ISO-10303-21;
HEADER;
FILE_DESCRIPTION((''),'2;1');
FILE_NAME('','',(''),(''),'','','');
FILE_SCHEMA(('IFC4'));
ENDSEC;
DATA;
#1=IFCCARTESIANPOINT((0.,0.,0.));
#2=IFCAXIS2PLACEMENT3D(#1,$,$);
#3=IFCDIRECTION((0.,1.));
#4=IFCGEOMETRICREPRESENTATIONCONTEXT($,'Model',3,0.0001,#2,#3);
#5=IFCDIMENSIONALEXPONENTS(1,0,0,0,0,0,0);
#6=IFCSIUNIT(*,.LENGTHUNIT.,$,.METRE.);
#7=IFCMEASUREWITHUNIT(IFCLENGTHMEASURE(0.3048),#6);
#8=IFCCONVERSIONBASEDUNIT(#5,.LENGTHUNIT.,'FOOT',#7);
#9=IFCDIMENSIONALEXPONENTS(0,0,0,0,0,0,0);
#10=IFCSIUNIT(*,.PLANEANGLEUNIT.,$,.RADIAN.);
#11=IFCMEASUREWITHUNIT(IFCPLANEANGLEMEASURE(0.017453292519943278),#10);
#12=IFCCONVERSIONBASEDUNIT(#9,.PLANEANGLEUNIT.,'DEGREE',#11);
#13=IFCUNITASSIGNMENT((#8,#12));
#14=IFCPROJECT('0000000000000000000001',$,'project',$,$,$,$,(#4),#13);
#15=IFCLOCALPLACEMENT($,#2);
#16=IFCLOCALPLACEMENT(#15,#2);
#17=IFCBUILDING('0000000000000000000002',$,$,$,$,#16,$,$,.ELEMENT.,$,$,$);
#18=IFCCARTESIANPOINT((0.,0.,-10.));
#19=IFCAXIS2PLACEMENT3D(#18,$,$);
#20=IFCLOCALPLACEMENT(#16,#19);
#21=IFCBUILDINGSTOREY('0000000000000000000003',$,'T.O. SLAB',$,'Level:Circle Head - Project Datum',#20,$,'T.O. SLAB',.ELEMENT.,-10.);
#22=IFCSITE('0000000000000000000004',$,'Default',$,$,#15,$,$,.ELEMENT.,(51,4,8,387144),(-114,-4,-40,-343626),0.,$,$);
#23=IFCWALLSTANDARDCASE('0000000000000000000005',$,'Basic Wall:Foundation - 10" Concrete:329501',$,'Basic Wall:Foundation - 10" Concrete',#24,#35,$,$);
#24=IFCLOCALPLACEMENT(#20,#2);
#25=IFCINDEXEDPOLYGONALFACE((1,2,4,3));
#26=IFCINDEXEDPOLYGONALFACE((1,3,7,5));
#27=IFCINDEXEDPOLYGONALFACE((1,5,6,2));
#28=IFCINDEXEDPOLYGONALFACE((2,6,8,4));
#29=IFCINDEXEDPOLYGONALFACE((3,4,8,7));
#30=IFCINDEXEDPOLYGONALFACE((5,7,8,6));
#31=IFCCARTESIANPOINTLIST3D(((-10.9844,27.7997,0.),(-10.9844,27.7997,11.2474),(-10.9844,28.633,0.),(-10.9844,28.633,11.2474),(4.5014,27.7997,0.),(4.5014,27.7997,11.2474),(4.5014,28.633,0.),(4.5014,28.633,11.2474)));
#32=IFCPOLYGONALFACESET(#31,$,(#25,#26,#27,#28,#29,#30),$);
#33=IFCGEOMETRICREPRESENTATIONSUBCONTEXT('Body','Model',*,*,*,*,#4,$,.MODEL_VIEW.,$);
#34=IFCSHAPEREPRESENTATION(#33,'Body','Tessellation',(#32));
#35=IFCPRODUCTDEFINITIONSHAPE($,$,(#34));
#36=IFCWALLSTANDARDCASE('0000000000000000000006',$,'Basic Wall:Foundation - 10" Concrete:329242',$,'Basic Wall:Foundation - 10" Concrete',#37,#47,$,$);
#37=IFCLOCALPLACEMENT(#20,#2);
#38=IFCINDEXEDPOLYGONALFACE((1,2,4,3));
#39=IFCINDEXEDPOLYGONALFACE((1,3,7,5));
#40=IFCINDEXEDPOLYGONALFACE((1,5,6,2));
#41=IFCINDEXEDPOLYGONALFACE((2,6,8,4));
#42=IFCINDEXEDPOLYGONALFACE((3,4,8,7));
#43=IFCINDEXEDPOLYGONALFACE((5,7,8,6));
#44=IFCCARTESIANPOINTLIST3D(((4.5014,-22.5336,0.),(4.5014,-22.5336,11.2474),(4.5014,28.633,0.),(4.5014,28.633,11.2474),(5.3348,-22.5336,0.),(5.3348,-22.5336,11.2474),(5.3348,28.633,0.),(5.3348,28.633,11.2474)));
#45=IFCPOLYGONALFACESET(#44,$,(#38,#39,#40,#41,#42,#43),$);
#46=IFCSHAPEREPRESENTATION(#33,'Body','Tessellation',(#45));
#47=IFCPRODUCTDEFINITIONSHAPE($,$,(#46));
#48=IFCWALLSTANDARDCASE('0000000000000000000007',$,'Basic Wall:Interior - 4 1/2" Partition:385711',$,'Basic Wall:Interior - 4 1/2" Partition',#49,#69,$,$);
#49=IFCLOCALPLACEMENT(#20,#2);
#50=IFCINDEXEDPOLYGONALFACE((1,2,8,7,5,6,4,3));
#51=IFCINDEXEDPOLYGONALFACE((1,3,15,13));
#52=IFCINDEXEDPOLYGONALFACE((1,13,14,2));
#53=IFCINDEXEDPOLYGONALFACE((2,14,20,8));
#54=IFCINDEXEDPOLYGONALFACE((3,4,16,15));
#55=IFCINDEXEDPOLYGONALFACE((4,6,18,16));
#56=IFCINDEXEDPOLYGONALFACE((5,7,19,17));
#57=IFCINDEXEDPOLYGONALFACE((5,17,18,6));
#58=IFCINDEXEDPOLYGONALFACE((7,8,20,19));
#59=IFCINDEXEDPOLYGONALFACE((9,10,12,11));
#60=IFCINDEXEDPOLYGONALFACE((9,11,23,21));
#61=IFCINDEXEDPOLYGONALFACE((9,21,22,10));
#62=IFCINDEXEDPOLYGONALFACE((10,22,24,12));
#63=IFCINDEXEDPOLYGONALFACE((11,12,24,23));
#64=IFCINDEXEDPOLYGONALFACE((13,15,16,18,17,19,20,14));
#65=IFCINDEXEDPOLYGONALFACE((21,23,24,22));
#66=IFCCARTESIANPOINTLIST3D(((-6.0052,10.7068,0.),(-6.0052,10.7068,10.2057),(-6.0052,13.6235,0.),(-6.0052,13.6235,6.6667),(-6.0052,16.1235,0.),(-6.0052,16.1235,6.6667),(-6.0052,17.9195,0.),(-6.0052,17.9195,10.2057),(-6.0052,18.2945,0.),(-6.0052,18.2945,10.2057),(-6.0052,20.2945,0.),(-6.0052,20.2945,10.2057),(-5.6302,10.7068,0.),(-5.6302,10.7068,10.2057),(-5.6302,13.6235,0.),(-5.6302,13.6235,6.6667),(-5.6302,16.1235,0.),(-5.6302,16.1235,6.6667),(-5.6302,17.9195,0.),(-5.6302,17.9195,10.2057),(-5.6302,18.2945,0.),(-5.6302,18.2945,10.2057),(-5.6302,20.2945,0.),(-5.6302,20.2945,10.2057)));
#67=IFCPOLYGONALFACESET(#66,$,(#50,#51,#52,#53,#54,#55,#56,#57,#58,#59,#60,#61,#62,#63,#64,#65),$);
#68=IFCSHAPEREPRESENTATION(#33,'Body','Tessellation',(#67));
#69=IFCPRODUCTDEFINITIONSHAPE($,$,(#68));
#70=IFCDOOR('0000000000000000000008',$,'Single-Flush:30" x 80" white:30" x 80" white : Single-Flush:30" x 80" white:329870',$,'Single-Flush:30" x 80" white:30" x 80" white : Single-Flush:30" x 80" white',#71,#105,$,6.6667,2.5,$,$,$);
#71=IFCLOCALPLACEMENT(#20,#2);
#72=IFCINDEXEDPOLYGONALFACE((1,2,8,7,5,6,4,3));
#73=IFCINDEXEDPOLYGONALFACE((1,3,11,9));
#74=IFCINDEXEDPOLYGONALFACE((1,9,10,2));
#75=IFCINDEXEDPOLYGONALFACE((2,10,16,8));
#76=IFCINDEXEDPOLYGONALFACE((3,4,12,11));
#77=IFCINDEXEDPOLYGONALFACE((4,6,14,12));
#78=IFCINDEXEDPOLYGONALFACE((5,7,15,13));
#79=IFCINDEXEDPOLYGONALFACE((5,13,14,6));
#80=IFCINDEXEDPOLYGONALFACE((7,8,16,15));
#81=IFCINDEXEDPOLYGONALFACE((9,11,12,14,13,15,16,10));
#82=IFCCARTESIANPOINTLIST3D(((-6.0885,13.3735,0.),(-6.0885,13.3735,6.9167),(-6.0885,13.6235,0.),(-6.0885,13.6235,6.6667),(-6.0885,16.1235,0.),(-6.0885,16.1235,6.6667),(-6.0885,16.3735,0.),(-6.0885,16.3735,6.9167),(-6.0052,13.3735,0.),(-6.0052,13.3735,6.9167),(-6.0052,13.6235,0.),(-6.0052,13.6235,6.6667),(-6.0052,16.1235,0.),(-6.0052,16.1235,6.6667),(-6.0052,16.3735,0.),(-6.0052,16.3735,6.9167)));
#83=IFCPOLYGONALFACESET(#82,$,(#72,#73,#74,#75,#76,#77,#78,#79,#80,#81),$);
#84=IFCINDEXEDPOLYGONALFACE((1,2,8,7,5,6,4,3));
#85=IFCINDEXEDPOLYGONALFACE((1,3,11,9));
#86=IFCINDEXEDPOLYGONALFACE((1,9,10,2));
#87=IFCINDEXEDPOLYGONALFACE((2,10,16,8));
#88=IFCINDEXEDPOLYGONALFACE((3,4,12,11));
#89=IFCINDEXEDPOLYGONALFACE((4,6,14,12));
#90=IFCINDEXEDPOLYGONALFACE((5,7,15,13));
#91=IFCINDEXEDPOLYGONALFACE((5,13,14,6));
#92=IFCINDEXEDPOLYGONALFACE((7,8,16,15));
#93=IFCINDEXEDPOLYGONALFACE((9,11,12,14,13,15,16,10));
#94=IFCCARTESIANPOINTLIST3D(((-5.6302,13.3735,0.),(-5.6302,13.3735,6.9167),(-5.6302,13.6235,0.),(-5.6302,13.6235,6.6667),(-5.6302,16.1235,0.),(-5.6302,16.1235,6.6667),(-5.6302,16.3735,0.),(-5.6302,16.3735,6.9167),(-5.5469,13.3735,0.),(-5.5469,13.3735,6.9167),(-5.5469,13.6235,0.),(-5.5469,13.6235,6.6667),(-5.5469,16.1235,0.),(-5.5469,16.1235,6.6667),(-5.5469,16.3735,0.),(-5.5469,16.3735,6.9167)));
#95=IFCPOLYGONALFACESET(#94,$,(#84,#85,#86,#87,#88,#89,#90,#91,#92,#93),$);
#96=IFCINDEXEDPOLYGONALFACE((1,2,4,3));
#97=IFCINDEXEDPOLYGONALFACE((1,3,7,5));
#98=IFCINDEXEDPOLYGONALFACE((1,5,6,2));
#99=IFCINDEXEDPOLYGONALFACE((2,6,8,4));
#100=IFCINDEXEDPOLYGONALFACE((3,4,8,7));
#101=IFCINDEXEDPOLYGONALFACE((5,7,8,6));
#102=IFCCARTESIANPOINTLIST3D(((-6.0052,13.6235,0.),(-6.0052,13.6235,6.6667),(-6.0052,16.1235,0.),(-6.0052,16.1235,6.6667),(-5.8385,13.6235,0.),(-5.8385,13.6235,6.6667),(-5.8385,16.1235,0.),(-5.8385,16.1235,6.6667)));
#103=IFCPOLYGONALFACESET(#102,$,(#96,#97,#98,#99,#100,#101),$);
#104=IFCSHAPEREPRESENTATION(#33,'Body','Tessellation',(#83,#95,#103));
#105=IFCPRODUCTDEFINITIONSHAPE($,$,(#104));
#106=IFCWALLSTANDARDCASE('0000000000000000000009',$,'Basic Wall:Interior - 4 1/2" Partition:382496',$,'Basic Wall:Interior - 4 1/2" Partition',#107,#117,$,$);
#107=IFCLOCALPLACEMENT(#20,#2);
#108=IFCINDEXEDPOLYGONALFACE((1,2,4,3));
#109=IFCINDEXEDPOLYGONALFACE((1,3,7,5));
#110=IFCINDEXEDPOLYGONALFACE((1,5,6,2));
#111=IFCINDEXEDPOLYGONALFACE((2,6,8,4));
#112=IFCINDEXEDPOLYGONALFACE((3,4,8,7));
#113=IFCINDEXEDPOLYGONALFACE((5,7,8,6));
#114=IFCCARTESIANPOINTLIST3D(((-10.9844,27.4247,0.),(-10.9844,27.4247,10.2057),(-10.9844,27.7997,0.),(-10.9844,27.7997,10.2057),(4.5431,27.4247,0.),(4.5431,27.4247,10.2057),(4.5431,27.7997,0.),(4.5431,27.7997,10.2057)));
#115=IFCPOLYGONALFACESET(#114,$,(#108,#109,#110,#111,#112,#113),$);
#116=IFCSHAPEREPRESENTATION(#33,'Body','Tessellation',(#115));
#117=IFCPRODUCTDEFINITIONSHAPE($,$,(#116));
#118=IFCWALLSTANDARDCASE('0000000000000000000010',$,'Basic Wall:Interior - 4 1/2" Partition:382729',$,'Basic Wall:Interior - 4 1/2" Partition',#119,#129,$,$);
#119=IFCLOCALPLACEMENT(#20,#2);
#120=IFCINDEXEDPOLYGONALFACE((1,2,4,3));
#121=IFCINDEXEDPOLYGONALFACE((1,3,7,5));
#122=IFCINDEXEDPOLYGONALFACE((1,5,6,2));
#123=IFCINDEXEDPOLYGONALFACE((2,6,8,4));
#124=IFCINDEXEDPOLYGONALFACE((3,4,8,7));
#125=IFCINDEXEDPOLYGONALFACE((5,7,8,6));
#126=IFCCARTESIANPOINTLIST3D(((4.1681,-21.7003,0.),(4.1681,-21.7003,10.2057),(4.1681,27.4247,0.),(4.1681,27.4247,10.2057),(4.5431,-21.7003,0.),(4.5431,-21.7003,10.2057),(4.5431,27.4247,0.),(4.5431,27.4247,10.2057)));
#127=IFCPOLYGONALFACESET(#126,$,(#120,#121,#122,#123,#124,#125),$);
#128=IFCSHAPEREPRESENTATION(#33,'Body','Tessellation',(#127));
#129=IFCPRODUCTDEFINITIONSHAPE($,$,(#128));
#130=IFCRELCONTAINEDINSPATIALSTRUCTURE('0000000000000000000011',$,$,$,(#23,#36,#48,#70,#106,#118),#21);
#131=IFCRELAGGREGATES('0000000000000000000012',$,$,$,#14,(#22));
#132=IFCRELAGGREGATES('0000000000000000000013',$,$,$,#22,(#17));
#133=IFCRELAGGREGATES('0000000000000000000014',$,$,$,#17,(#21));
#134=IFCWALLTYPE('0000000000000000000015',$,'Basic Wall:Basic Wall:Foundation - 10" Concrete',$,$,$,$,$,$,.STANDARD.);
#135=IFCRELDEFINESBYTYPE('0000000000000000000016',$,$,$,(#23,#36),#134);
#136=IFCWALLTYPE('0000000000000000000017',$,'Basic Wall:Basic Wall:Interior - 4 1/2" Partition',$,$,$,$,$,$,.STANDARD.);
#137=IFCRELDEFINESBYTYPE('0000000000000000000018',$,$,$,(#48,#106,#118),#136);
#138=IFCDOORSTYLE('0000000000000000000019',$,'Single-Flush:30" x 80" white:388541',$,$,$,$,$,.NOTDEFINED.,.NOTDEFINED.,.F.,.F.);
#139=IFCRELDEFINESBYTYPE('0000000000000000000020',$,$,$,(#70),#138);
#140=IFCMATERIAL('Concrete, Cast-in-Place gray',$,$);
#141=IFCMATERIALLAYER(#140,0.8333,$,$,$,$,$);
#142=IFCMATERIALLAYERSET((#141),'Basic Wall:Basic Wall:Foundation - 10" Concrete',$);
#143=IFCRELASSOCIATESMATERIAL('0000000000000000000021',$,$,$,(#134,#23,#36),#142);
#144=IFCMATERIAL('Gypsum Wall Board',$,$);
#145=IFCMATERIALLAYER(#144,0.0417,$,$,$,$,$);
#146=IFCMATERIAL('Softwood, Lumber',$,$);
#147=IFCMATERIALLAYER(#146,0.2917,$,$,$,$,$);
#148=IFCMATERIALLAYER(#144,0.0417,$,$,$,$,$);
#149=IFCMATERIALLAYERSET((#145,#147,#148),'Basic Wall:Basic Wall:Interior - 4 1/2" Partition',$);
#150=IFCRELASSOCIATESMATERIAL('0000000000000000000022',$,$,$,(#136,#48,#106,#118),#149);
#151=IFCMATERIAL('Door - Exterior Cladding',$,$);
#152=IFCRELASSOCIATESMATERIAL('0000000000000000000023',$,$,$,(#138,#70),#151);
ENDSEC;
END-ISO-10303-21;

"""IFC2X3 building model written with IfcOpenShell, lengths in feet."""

from ifc_helpers import new_model, entity, si_unit, converted_unit, direction, frame, frame_2d, origin, origin_2d_with_axis, place, context, subcontext, project, spatial, polyline, rectangle, outline, extrude, source, transform, mapped, material, layer, layer_set, layer_usage, type_object, type_shapes, element, fill, save


model = new_model("IFC2X3")

# Units and contexts
model_context = context("Model", 3, precision=0.0001, world=origin(), true_north=direction((0.0, 1.0)))
body_context = subcontext(model_context, "Body", "Model", "MODEL_VIEW")
ifc_project = project(units=[converted_unit("LENGTHUNIT", "FOOT", entity("IfcLengthMeasure", 0.3048), si_unit("LENGTHUNIT", "METRE"), dimensions=[1, 0, 0, 0, 0, 0, 0]), converted_unit("PLANEANGLEUNIT", "DEGREE", entity("IfcPlaneAngleMeasure", 0.017453292519943278), si_unit("PLANEANGLEUNIT", "RADIAN"), dimensions=[0, 0, 0, 0, 0, 0, 0])], contexts=[model_context])

# Site, building, storey
site_placement = place(None, origin())
site = spatial("IfcSite", under=ifc_project, at=site_placement, Name="Default", CompositionType="ELEMENT", RefLatitude=(51, 4, 8, 387144), RefLongitude=(-114, -4, -40, -343626), RefElevation=0.0)
building_placement = place(site_placement, origin())
building = spatial("IfcBuilding", under=site, at=building_placement, CompositionType="ELEMENT")
storey_placement = place(building_placement, frame((0.0, 0.0, -10.0)))
storey = spatial("IfcBuildingStorey", under=building, at=storey_placement, Name="T.O. SLAB", ObjectType="Level:Circle Head - Project Datum", LongName="T.O. SLAB", CompositionType="ELEMENT", Elevation=-10.0)

# Wall, opening
ifc_material_1 = material(Name="Concrete, Cast-in-Place gray")
ifc_layer_1 = layer(ifc_material_1, 0.8333)
ifc_layer_set_1 = layer_set([ifc_layer_1], Name="Basic Wall:Basic Wall:Foundation - 10\" Concrete")
ifc_layer_usage_1 = layer_usage(ifc_layer_set_1, "AXIS2", "NEGATIVE", 0.4167)
wall_type_1 = type_object("IfcWallType", Name="Basic Wall:Basic Wall:Foundation - 10\" Concrete", PredefinedType="STANDARD", material=ifc_layer_set_1)
wall_1_placement = place(storey_placement, frame((-10.9844, 28.2164, 0.0)))
wall_1 = element("IfcWallStandardCase", 1, at=wall_1_placement, inside=storey, type_object=wall_type_1, material=ifc_layer_usage_1, Name="Basic Wall:Foundation - 10\" Concrete:329501", ObjectType="Basic Wall:Foundation - 10\" Concrete", context=body_context, shape_type="SweptSolid", body=[
    extrude(rectangle(XDim=15.4858, YDim=0.8333, at=frame_2d((7.7429, 0.0), x_axis=(-1.0, 0.0))), origin(), (0.0, 0.0, 1.0), 11.2474),
])
opening_1_placement = place(wall_1_placement, origin())
element("IfcOpeningElement", 2, at=opening_1_placement, cuts=wall_1, ObjectType="Opening", context=body_context, shape_type="SweptSolid", body=[
    extrude(rectangle(XDim=6.8437, YDim=9.6562, at=origin_2d_with_axis()), frame((7.7429, -0.4167, 14.6693), z_axis=(0.0, 1.0, 0.0), x_axis=(0.0, 0.0, -1.0)), (0.0, 0.0, 1.0), 0.8333),
])

# Wall
ifc_layer_usage_2 = layer_usage(ifc_layer_set_1, "AXIS2", "NEGATIVE", 0.4167)
wall_2_placement = place(storey_placement, frame((4.9181, 28.633, 0.0), z_axis=(0.0, 0.0, 1.0), x_axis=(0.0, -1.0, 0.0)))
element("IfcWallStandardCase", 3, at=wall_2_placement, inside=storey, type_object=wall_type_1, material=ifc_layer_usage_2, Name="Basic Wall:Foundation - 10\" Concrete:329242", ObjectType="Basic Wall:Foundation - 10\" Concrete", context=body_context, shape_type="SweptSolid", body=[
    extrude(rectangle(XDim=51.1667, YDim=0.8333, at=frame_2d((25.5833, 0.0), x_axis=(-1.0, 0.0))), origin(), (0.0, 0.0, 1.0), 11.2474),
])

# Wall, openings, door
ifc_material_2 = material(Name="Gypsum Wall Board")
ifc_layer_2 = layer(ifc_material_2, 0.0417)
ifc_material_3 = material(Name="Softwood, Lumber")
ifc_layer_3 = layer(ifc_material_3, 0.2917)
ifc_layer_4 = layer(ifc_material_2, 0.0417)
ifc_layer_set_2 = layer_set([ifc_layer_2, ifc_layer_3, ifc_layer_4], Name="Basic Wall:Basic Wall:Interior - 4 1/2\" Partition")
ifc_layer_usage_3 = layer_usage(ifc_layer_set_2, "AXIS2", "NEGATIVE", 0.1875)
wall_type_2 = type_object("IfcWallType", Name="Basic Wall:Basic Wall:Interior - 4 1/2\" Partition", PredefinedType="STANDARD", material=ifc_layer_set_2)
wall_3_placement = place(storey_placement, frame((-5.8177, 20.2945, 0.0), z_axis=(0.0, 0.0, 1.0), x_axis=(0.0, -1.0, 0.0)))
wall_3 = element("IfcWallStandardCase", 4, at=wall_3_placement, inside=storey, type_object=wall_type_2, material=ifc_layer_usage_3, Name="Basic Wall:Interior - 4 1/2\" Partition:385711", ObjectType="Basic Wall:Interior - 4 1/2\" Partition", context=body_context, shape_type="SweptSolid", body=[
    extrude(rectangle(XDim=9.5877, YDim=0.375, at=frame_2d((4.7938, 0.0), x_axis=(-1.0, 0.0))), origin(), (0.0, 0.0, 1.0), 10.2057),
])
opening_2_placement = place(wall_3_placement, origin())
element("IfcOpeningElement", 5, at=opening_2_placement, cuts=wall_3, ObjectType="Opening", context=body_context, shape_type="SweptSolid", body=[
    extrude(rectangle(XDim=10.2057, YDim=0.375, at=frame_2d((0.0, 0.0), x_axis=(0.0, 1.0))), frame((2.1875, -0.1875, 5.1029), z_axis=(0.0, 1.0, 0.0), x_axis=(1.0, 0.0, 0.0)), (0.0, 0.0, 1.0), 0.375),
])
opening_3_placement = place(wall_3_placement, frame((20.2945, 5.8177, 0.0), z_axis=(0.0, 0.0, 1.0), x_axis=(0.0, 1.0, 0.0)))
opening_3 = element("IfcOpeningElement", 6, at=opening_3_placement, cuts=wall_3, ObjectType="Opening", context=body_context, shape_type="SweptSolid", body=[
    extrude(rectangle(XDim=6.6667, YDim=2.5, at=frame_2d((0.0, 0.0), x_axis=(0.0, 1.0))), frame((-6.009, 14.8735, 3.3333), z_axis=(1.0, 0.0, 0.0), x_axis=(0.0, -1.0, 0.0)), (0.0, 0.0, 1.0), 0.3825),
])
ifc_material_4 = material(Name="Door - Exterior Cladding")
door_style_1 = type_object("IfcDoorStyle", Name="Single-Flush:30\" x 80\" white:388541", ConstructionType="NOTDEFINED", OperationType="NOTDEFINED", ParameterTakesPrecedence=False, Sizeable=False, material=ifc_material_4)
shared_shape_1 = source(origin(), body_context, "Body", "SweptSolid", [
    extrude(outline(polyline([(-3.5208, -1.5), (3.3958, -1.5), (3.3958, -1.25), (-3.2708, -1.25), (-3.2708, 1.25), (3.3958, 1.25), (3.3958, 1.5), (-3.5208, 1.5), (-3.5208, -1.5)])), frame((1.25, 0.3788, 3.3958), z_axis=(0.0, 1.0, 0.0), x_axis=(0.0, 0.0, -1.0)), (0.0, 0.0, 1.0), 0.0833),
    extrude(outline(polyline([(-1.5, -3.3958), (-1.25, -3.3958), (-1.25, 3.2708), (1.25, 3.2708), (1.25, -3.3958), (1.5, -3.3958), (1.5, 3.5208), (-1.5, 3.5208), (-1.5, -3.3958)])), frame((1.25, -0.0796, 3.3958), z_axis=(0.0, 1.0, 0.0), x_axis=(-1.0, 0.0, 0.0)), (0.0, 0.0, 1.0), 0.0833),
    extrude(rectangle(XDim=2.5, YDim=0.1667, at=origin_2d_with_axis()), frame((1.25, 0.2954, 0.0), z_axis=(0.0, 0.0, 1.0), x_axis=(-1.0, 0.0, 0.0)), (0.0, 0.0, 1.0), 6.6667),
])
type_shapes(door_style_1, [shared_shape_1])
door_1_placement = place(opening_3_placement, frame((-5.6265, 13.6235, 0.0), z_axis=(0.0, 0.0, 1.0), x_axis=(0.0, 1.0, 0.0)))
door_1 = element("IfcDoor", 7, at=door_1_placement, inside=storey, type_object=door_style_1, material=ifc_material_4, Name="Single-Flush:30\" x 80\" white:30\" x 80\" white : Single-Flush:30\" x 80\" white:329870", ObjectType="Single-Flush:30\" x 80\" white:30\" x 80\" white : Single-Flush:30\" x 80\" white", OverallHeight=6.6667, OverallWidth=2.5, context=body_context, shape_type="MappedRepresentation", body=[
    mapped(shared_shape_1, transform((0.0, 0.0, 0.0), scale=1.0)),
])
fill(opening_3, door_1)

# Walls
ifc_layer_usage_4 = layer_usage(ifc_layer_set_2, "AXIS2", "NEGATIVE", 0.1875)
wall_4_placement = place(storey_placement, frame((-10.9844, 27.6122, 0.0)))
element("IfcWallStandardCase", 8, at=wall_4_placement, inside=storey, type_object=wall_type_2, material=ifc_layer_usage_4, Name="Basic Wall:Interior - 4 1/2\" Partition:382496", ObjectType="Basic Wall:Interior - 4 1/2\" Partition", context=body_context, shape_type="SweptSolid", body=[
    extrude(rectangle(XDim=15.5275, YDim=0.375, at=frame_2d((7.7637, 0.0), x_axis=(-1.0, 0.0))), origin(), (0.0, 0.0, 1.0), 10.2057),
])
ifc_layer_usage_5 = layer_usage(ifc_layer_set_2, "AXIS2", "NEGATIVE", 0.1875)
wall_5_placement = place(storey_placement, frame((4.3556, 27.4247, 0.0), z_axis=(0.0, 0.0, 1.0), x_axis=(0.0, -1.0, 0.0)))
element("IfcWallStandardCase", 9, at=wall_5_placement, inside=storey, type_object=wall_type_2, material=ifc_layer_usage_5, Name="Basic Wall:Interior - 4 1/2\" Partition:382729", ObjectType="Basic Wall:Interior - 4 1/2\" Partition", context=body_context, shape_type="SweptSolid", body=[
    extrude(rectangle(XDim=49.125, YDim=0.375, at=frame_2d((24.5625, 0.0), x_axis=(-1.0, 0.0))), origin(), (0.0, 0.0, 1.0), 10.2057),
])

save(model, "model.ifc")
